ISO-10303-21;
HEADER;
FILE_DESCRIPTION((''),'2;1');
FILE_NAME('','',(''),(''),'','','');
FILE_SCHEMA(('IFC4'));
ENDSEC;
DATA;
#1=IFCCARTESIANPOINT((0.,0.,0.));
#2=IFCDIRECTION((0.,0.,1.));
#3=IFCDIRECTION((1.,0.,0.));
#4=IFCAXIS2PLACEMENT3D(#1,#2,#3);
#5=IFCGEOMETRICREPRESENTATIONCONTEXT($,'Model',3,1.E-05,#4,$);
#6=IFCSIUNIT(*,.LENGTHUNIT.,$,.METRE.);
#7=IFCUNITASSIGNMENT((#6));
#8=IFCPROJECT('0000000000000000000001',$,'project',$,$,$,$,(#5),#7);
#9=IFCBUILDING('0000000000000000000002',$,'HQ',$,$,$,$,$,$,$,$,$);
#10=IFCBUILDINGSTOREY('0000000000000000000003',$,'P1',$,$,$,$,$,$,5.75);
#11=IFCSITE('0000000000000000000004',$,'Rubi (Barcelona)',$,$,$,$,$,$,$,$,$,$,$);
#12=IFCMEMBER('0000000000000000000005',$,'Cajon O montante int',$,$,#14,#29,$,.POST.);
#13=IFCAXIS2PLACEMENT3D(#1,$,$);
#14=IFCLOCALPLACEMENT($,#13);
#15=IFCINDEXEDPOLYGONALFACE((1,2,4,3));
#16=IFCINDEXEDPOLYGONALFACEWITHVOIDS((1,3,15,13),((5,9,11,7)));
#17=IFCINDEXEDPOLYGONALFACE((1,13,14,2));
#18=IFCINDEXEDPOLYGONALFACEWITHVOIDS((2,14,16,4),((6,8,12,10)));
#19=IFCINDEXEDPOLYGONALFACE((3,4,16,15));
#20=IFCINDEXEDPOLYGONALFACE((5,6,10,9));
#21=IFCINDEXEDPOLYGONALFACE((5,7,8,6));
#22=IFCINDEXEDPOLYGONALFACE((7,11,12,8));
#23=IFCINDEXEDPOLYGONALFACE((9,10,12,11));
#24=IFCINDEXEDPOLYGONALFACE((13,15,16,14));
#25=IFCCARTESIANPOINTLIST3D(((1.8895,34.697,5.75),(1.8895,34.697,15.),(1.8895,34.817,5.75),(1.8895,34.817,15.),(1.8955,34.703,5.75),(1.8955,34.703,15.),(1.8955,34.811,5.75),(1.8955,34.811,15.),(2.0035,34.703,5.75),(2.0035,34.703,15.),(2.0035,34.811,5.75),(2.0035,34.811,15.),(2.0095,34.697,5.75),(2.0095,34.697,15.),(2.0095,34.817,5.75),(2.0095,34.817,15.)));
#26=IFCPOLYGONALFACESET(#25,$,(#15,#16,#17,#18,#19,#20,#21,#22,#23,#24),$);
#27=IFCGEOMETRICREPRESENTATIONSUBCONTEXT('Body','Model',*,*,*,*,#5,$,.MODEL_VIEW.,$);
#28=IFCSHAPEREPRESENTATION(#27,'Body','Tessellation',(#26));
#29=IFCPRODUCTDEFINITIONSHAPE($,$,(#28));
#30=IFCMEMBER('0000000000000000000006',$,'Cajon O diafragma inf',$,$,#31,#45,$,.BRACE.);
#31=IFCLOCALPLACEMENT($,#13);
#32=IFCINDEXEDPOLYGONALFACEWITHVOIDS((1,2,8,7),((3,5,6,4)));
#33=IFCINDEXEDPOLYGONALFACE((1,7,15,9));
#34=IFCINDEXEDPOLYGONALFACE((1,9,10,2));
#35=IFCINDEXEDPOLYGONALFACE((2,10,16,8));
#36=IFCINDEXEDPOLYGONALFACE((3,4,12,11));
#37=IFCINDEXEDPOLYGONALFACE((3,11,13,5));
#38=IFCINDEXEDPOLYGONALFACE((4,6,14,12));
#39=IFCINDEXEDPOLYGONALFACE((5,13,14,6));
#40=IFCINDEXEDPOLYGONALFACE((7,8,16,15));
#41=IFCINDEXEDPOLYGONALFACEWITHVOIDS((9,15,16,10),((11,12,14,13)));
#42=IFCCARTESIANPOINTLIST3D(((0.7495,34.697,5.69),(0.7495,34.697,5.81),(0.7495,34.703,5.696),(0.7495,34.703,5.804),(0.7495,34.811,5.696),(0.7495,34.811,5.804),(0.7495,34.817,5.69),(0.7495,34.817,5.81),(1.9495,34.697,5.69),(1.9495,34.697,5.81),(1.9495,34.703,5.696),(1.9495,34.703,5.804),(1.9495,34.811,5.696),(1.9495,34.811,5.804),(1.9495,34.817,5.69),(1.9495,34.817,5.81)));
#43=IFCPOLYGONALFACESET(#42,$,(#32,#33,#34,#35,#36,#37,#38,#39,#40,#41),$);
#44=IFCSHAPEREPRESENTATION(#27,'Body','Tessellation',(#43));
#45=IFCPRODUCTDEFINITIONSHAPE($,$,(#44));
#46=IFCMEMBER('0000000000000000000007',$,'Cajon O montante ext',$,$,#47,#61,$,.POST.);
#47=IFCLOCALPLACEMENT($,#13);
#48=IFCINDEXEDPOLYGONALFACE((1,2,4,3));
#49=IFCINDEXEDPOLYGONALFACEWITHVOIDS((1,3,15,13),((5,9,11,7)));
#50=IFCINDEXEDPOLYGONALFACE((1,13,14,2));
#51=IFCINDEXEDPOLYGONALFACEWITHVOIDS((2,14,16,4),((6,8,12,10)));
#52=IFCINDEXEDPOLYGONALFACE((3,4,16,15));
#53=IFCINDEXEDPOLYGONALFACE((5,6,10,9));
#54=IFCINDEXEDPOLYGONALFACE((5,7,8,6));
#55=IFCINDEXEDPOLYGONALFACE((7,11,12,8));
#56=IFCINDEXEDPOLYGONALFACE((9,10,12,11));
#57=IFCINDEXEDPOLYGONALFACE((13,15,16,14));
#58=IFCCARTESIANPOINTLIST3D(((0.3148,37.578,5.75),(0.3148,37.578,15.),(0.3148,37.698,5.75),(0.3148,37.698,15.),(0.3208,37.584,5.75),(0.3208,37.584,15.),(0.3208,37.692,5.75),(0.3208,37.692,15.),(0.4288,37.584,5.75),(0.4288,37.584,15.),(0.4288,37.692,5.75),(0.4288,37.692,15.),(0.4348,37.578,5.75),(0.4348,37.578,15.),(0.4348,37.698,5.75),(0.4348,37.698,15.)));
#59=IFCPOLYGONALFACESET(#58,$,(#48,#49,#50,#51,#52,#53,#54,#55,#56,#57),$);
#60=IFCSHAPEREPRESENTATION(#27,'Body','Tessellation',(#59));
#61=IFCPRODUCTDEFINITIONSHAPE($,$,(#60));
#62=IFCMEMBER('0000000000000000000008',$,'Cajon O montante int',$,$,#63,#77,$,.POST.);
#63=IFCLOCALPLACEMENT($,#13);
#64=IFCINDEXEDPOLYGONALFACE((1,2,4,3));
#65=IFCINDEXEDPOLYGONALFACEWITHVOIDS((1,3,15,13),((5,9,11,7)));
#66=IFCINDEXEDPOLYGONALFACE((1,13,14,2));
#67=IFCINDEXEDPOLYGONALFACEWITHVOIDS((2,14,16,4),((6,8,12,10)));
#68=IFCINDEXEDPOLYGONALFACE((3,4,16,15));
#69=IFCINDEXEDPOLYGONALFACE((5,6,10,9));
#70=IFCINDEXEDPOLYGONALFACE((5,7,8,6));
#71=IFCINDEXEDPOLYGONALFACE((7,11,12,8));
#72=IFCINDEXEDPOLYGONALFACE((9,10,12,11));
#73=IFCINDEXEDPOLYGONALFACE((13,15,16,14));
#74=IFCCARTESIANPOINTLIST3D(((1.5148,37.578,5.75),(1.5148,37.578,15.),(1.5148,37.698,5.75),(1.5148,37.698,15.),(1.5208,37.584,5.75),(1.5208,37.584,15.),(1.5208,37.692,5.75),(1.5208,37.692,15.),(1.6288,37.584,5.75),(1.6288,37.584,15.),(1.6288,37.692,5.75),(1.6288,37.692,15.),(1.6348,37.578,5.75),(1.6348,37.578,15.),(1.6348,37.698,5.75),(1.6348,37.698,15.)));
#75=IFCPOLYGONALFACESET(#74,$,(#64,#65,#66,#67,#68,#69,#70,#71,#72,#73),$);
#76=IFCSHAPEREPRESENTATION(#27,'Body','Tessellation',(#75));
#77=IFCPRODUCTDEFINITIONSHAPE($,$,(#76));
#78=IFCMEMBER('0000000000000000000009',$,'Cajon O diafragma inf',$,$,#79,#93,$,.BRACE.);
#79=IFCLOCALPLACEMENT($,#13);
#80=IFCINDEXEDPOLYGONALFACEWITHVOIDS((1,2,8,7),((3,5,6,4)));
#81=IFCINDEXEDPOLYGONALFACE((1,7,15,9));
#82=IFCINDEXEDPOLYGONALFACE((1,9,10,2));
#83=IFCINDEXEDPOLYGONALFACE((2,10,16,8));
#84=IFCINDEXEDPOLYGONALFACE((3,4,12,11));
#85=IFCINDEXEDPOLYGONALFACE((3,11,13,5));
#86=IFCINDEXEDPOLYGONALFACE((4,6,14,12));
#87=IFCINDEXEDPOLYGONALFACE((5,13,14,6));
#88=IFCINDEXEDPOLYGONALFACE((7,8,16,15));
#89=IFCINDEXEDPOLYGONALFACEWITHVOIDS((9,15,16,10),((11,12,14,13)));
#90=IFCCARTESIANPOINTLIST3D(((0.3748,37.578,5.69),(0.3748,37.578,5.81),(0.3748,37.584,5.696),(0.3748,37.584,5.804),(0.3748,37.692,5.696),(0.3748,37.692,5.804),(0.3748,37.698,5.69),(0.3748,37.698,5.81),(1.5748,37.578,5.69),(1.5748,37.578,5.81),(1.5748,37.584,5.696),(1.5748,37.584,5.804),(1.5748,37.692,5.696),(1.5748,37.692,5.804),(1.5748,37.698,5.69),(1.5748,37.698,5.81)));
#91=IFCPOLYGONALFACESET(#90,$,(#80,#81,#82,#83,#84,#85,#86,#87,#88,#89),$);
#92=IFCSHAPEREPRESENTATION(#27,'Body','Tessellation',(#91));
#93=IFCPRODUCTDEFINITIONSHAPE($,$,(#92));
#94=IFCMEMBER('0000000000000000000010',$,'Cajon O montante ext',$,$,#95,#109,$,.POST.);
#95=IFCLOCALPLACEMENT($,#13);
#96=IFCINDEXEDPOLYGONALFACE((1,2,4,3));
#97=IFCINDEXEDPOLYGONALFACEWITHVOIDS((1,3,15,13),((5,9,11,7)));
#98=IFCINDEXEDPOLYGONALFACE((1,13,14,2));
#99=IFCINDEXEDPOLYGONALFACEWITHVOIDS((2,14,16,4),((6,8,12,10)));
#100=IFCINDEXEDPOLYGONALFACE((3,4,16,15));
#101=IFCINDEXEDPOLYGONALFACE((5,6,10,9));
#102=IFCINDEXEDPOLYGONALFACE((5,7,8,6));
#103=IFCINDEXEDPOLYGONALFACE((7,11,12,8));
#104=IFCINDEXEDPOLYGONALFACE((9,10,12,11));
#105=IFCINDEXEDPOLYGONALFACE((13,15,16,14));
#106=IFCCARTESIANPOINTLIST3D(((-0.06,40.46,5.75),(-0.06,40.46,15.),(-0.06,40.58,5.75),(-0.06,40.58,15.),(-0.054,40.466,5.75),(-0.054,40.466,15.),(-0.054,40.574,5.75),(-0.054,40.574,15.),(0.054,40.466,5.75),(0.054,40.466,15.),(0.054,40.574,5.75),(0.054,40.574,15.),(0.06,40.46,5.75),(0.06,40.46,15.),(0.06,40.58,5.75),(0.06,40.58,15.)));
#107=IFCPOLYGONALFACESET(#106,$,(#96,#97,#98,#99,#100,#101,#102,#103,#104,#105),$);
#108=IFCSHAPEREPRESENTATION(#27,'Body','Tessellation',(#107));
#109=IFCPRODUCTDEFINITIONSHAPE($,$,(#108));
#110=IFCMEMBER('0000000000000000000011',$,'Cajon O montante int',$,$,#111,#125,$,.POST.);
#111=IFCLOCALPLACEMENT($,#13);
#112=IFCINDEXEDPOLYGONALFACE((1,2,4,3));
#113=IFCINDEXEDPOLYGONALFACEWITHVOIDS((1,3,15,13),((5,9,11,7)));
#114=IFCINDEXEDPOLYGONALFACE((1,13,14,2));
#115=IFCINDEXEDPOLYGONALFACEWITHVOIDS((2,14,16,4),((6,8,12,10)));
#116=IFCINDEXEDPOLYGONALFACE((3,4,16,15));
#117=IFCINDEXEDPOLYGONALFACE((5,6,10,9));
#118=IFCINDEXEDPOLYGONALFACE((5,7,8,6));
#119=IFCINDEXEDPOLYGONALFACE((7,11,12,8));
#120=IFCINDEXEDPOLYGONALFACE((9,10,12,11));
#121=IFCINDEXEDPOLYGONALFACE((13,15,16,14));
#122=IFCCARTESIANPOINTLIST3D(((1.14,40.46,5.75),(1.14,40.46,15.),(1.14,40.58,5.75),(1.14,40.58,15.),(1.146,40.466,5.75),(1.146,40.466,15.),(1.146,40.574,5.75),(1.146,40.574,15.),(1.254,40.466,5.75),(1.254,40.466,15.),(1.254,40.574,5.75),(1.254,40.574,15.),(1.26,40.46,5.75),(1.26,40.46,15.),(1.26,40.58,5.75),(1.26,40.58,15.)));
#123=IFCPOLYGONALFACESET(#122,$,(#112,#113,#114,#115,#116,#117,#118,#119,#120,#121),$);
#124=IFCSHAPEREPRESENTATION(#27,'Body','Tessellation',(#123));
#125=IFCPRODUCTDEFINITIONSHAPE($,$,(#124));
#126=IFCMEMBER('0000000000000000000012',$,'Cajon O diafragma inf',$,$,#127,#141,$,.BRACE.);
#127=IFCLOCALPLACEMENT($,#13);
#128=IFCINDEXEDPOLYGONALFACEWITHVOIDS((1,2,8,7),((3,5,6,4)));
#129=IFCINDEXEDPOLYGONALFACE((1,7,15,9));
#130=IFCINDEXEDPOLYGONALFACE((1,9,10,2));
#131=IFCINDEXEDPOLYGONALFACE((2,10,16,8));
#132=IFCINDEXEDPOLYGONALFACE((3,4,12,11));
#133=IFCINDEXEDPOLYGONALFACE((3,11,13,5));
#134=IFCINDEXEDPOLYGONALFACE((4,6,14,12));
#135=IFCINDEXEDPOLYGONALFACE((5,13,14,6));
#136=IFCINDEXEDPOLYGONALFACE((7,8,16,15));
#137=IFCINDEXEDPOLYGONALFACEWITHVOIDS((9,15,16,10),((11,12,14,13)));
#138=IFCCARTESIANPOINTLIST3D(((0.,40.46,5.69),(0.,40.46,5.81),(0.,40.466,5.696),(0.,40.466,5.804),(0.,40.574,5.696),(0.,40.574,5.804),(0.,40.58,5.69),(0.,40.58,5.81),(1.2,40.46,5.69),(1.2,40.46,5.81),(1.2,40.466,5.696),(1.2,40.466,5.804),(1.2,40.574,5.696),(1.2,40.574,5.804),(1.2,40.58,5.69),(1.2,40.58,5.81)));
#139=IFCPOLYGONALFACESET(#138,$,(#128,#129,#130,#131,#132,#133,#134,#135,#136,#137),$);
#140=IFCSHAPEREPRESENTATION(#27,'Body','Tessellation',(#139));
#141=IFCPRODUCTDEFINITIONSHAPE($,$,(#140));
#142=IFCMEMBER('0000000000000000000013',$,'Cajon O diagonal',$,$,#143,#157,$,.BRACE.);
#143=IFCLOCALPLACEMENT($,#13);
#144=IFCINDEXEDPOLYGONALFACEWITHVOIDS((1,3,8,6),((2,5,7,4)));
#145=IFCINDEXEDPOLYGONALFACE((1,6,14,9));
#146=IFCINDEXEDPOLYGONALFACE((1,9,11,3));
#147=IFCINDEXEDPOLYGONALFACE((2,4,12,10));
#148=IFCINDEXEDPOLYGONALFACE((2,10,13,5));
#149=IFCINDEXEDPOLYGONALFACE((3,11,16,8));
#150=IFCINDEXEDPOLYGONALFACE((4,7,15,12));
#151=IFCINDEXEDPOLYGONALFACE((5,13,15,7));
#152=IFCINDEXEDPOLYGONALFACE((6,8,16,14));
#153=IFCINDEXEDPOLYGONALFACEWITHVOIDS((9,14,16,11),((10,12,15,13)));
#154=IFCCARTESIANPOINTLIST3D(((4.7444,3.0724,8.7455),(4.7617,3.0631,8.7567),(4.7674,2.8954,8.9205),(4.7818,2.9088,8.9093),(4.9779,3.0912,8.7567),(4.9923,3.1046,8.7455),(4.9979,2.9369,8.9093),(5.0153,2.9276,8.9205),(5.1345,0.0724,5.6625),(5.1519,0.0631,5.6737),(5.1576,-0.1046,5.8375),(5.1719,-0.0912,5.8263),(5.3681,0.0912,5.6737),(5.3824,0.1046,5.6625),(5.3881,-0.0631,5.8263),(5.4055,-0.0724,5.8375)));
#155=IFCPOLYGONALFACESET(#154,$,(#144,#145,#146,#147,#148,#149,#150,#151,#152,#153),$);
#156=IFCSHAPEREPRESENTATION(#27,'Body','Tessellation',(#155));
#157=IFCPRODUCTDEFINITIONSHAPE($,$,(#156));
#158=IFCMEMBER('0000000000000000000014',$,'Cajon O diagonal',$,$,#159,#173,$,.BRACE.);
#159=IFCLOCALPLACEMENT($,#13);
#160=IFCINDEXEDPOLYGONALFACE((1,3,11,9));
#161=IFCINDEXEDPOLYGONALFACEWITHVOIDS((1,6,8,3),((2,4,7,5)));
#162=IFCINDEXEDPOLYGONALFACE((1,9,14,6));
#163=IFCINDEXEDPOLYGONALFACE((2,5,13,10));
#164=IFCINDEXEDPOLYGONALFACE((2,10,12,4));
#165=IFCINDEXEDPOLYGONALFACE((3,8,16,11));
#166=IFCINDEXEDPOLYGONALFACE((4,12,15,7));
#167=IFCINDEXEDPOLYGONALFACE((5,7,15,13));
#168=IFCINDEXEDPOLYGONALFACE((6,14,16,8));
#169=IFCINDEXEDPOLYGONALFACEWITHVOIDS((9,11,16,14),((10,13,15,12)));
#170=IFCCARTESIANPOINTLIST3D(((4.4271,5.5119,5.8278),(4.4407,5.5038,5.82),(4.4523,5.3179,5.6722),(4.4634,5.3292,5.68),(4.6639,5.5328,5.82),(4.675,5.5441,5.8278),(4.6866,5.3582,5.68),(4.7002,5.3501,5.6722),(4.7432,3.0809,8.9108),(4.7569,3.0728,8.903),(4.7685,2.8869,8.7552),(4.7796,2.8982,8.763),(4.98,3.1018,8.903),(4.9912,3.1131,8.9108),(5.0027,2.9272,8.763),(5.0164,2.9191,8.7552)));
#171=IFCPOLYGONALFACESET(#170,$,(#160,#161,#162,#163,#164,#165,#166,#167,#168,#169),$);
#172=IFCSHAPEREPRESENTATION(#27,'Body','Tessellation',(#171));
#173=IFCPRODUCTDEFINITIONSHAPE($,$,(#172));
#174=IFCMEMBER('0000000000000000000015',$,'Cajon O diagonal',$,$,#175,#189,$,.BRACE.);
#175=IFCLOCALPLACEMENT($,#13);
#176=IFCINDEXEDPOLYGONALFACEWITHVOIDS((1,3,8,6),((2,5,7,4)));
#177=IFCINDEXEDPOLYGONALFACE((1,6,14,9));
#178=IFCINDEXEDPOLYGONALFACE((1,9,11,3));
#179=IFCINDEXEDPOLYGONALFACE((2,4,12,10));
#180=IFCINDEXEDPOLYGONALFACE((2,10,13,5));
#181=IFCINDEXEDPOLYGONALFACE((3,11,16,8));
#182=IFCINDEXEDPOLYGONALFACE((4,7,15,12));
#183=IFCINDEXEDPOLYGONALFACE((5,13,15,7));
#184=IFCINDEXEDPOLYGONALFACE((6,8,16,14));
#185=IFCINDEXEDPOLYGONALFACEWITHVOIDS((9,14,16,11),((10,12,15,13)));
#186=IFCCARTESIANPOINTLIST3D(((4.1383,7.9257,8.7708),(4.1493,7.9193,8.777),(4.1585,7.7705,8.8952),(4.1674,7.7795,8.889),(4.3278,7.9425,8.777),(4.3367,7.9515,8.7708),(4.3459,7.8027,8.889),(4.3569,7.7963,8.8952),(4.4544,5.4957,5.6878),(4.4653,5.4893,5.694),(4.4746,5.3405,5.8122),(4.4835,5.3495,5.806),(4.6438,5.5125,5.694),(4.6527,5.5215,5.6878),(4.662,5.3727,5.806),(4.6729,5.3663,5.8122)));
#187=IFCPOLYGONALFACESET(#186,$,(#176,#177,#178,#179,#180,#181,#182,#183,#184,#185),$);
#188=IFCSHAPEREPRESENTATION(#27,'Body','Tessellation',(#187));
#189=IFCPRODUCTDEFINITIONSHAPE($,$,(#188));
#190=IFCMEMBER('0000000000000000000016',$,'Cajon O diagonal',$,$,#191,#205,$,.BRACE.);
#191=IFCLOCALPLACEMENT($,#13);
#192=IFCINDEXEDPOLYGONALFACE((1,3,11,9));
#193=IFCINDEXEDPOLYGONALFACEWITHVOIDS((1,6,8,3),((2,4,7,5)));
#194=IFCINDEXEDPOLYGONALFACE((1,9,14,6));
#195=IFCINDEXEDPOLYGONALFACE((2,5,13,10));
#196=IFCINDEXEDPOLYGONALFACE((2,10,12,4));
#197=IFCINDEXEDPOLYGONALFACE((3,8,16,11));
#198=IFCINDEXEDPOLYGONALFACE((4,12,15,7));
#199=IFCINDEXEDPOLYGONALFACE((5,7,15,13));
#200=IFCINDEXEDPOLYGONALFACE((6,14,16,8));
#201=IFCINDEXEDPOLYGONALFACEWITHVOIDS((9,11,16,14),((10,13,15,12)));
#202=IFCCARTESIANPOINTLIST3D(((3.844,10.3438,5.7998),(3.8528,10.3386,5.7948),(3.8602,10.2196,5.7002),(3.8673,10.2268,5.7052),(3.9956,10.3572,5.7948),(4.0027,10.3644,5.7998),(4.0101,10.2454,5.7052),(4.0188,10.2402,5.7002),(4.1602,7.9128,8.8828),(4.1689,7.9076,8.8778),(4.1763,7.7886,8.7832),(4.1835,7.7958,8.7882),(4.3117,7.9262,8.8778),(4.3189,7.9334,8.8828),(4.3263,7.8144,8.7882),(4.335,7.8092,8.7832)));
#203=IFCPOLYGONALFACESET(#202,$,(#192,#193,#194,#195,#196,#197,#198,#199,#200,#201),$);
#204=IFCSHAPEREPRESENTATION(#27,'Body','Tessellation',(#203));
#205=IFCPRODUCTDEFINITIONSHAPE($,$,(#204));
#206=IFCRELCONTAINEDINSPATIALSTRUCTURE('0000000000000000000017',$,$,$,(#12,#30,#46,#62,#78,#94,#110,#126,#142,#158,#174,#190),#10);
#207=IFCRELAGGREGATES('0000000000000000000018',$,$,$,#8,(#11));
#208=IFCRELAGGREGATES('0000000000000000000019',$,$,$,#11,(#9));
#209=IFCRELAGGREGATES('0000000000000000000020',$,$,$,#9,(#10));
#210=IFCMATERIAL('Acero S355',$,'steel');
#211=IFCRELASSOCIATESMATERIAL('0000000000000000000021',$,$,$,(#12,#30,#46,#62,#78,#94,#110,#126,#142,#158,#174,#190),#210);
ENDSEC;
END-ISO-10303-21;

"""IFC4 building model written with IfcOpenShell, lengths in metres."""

from ifc_helpers import new_model, si_unit, frame, origin_with_axes, place, context, subcontext, project, spatial, hollow_rectangle, extrude, material, element, save


model = new_model("IFC4")

# Units and contexts
model_context = context("Model", 3, precision=1e-05, world=origin_with_axes())
body_context = subcontext(model_context, "Body", "Model", "MODEL_VIEW")
ifc_project = project(units=[si_unit("LENGTHUNIT", "METRE")], contexts=[model_context])

# Site, building, storey
site = spatial("IfcSite", under=ifc_project, Name="Rubi (Barcelona)")
building = spatial("IfcBuilding", under=site, Name="HQ")
storey = spatial("IfcBuildingStorey", under=building, Name="P1", Elevation=5.75)

# Members
ifc_material = material(Name="Acero S355", Category="steel")
member_1_placement = place(None, origin_with_axes())
element("IfcMember", 1, at=member_1_placement, inside=storey, material=ifc_material, Name="Cajon O montante int", PredefinedType="POST", context=body_context, shape_type="SweptSolid", body=[
    extrude(hollow_rectangle(XDim=0.12, YDim=0.12, WallThickness=0.006), frame((1.9495, 34.757, 5.75), z_axis=(0.0, 0.0, 1.0), x_axis=(1.0, 0.0, 0.0)), (0.0, 0.0, 1.0), 9.25),
])
member_2_placement = place(None, origin_with_axes())
element("IfcMember", 2, at=member_2_placement, inside=storey, material=ifc_material, Name="Cajon O diafragma inf", PredefinedType="BRACE", context=body_context, shape_type="SweptSolid", body=[
    extrude(hollow_rectangle(XDim=0.12, YDim=0.12, WallThickness=0.006), frame((0.7495, 34.757, 5.75), z_axis=(1.0, 0.0, 0.0), x_axis=(0.0, 1.0, 0.0)), (0.0, 0.0, 1.0), 1.2),
])
member_3_placement = place(None, origin_with_axes())
element("IfcMember", 3, at=member_3_placement, inside=storey, material=ifc_material, Name="Cajon O montante ext", PredefinedType="POST", context=body_context, shape_type="SweptSolid", body=[
    extrude(hollow_rectangle(XDim=0.12, YDim=0.12, WallThickness=0.006), frame((0.3748, 37.638, 5.75), z_axis=(0.0, 0.0, 1.0), x_axis=(1.0, 0.0, 0.0)), (0.0, 0.0, 1.0), 9.25),
])
member_4_placement = place(None, origin_with_axes())
element("IfcMember", 4, at=member_4_placement, inside=storey, material=ifc_material, Name="Cajon O montante int", PredefinedType="POST", context=body_context, shape_type="SweptSolid", body=[
    extrude(hollow_rectangle(XDim=0.12, YDim=0.12, WallThickness=0.006), frame((1.5748, 37.638, 5.75), z_axis=(0.0, 0.0, 1.0), x_axis=(1.0, 0.0, 0.0)), (0.0, 0.0, 1.0), 9.25),
])
member_5_placement = place(None, origin_with_axes())
element("IfcMember", 5, at=member_5_placement, inside=storey, material=ifc_material, Name="Cajon O diafragma inf", PredefinedType="BRACE", context=body_context, shape_type="SweptSolid", body=[
    extrude(hollow_rectangle(XDim=0.12, YDim=0.12, WallThickness=0.006), frame((0.3748, 37.638, 5.75), z_axis=(1.0, 0.0, 0.0), x_axis=(0.0, 1.0, 0.0)), (0.0, 0.0, 1.0), 1.2),
])
member_6_placement = place(None, origin_with_axes())
element("IfcMember", 6, at=member_6_placement, inside=storey, material=ifc_material, Name="Cajon O montante ext", PredefinedType="POST", context=body_context, shape_type="SweptSolid", body=[
    extrude(hollow_rectangle(XDim=0.12, YDim=0.12, WallThickness=0.006), frame((0.0, 40.52, 5.75), z_axis=(0.0, 0.0, 1.0), x_axis=(1.0, 0.0, 0.0)), (0.0, 0.0, 1.0), 9.25),
])
member_7_placement = place(None, origin_with_axes())
element("IfcMember", 7, at=member_7_placement, inside=storey, material=ifc_material, Name="Cajon O montante int", PredefinedType="POST", context=body_context, shape_type="SweptSolid", body=[
    extrude(hollow_rectangle(XDim=0.12, YDim=0.12, WallThickness=0.006), frame((1.2, 40.52, 5.75), z_axis=(0.0, 0.0, 1.0), x_axis=(1.0, 0.0, 0.0)), (0.0, 0.0, 1.0), 9.25),
])
member_8_placement = place(None, origin_with_axes())
element("IfcMember", 8, at=member_8_placement, inside=storey, material=ifc_material, Name="Cajon O diafragma inf", PredefinedType="BRACE", context=body_context, shape_type="SweptSolid", body=[
    extrude(hollow_rectangle(XDim=0.12, YDim=0.12, WallThickness=0.006), frame((0.0, 40.52, 5.75), z_axis=(1.0, 0.0, 0.0), x_axis=(0.0, 1.0, 0.0)), (0.0, 0.0, 1.0), 1.2),
])
member_9_placement = place(None, origin_with_axes())
element("IfcMember", 9, at=member_9_placement, inside=storey, material=ifc_material, Name="Cajon O diagonal", PredefinedType="BRACE", context=body_context, shape_type="SweptSolid", body=[
    extrude(hollow_rectangle(XDim=0.25, YDim=0.25, WallThickness=0.016), frame((5.27, 0.0, 5.75), z_axis=(-0.090332, 0.694543, 0.713758), x_axis=(-0.991648, -0.128973, 0.0)), (0.0, 0.0, 1.0), 4.3194),
])
member_10_placement = place(None, origin_with_axes())
element("IfcMember", 10, at=member_10_placement, inside=storey, material=ifc_material, Name="Cajon O diagonal", PredefinedType="BRACE", context=body_context, shape_type="SweptSolid", body=[
    extrude(hollow_rectangle(XDim=0.25, YDim=0.25, WallThickness=0.0125), frame((4.5636, 5.431, 5.75), z_axis=(0.08027, -0.617184, 0.782714), x_axis=(0.991648, 0.128973, 0.0)), (0.0, 0.0, 1.0), 3.9389),
])
member_11_placement = place(None, origin_with_axes())
element("IfcMember", 11, at=member_11_placement, inside=storey, material=ifc_material, Name="Cajon O diagonal", PredefinedType="BRACE", context=body_context, shape_type="SweptSolid", body=[
    extrude(hollow_rectangle(XDim=0.2, YDim=0.2, WallThickness=0.01), frame((4.5636, 5.431, 5.75), z_axis=(-0.08025, 0.617028, 0.782839), x_axis=(-0.991648, -0.128973, 0.0)), (0.0, 0.0, 1.0), 3.9382),
])
member_12_placement = place(None, origin_with_axes())
element("IfcMember", 12, at=member_12_placement, inside=storey, material=ifc_material, Name="Cajon O diagonal", PredefinedType="BRACE", context=body_context, shape_type="SweptSolid", body=[
    extrude(hollow_rectangle(XDim=0.16, YDim=0.16, WallThickness=0.008), frame((3.9314, 10.292, 5.75), z_axis=(0.08027, -0.617184, 0.782714), x_axis=(0.991648, 0.128973, 0.0)), (0.0, 0.0, 1.0), 3.9389),
])

save(model, "model.ifc")
